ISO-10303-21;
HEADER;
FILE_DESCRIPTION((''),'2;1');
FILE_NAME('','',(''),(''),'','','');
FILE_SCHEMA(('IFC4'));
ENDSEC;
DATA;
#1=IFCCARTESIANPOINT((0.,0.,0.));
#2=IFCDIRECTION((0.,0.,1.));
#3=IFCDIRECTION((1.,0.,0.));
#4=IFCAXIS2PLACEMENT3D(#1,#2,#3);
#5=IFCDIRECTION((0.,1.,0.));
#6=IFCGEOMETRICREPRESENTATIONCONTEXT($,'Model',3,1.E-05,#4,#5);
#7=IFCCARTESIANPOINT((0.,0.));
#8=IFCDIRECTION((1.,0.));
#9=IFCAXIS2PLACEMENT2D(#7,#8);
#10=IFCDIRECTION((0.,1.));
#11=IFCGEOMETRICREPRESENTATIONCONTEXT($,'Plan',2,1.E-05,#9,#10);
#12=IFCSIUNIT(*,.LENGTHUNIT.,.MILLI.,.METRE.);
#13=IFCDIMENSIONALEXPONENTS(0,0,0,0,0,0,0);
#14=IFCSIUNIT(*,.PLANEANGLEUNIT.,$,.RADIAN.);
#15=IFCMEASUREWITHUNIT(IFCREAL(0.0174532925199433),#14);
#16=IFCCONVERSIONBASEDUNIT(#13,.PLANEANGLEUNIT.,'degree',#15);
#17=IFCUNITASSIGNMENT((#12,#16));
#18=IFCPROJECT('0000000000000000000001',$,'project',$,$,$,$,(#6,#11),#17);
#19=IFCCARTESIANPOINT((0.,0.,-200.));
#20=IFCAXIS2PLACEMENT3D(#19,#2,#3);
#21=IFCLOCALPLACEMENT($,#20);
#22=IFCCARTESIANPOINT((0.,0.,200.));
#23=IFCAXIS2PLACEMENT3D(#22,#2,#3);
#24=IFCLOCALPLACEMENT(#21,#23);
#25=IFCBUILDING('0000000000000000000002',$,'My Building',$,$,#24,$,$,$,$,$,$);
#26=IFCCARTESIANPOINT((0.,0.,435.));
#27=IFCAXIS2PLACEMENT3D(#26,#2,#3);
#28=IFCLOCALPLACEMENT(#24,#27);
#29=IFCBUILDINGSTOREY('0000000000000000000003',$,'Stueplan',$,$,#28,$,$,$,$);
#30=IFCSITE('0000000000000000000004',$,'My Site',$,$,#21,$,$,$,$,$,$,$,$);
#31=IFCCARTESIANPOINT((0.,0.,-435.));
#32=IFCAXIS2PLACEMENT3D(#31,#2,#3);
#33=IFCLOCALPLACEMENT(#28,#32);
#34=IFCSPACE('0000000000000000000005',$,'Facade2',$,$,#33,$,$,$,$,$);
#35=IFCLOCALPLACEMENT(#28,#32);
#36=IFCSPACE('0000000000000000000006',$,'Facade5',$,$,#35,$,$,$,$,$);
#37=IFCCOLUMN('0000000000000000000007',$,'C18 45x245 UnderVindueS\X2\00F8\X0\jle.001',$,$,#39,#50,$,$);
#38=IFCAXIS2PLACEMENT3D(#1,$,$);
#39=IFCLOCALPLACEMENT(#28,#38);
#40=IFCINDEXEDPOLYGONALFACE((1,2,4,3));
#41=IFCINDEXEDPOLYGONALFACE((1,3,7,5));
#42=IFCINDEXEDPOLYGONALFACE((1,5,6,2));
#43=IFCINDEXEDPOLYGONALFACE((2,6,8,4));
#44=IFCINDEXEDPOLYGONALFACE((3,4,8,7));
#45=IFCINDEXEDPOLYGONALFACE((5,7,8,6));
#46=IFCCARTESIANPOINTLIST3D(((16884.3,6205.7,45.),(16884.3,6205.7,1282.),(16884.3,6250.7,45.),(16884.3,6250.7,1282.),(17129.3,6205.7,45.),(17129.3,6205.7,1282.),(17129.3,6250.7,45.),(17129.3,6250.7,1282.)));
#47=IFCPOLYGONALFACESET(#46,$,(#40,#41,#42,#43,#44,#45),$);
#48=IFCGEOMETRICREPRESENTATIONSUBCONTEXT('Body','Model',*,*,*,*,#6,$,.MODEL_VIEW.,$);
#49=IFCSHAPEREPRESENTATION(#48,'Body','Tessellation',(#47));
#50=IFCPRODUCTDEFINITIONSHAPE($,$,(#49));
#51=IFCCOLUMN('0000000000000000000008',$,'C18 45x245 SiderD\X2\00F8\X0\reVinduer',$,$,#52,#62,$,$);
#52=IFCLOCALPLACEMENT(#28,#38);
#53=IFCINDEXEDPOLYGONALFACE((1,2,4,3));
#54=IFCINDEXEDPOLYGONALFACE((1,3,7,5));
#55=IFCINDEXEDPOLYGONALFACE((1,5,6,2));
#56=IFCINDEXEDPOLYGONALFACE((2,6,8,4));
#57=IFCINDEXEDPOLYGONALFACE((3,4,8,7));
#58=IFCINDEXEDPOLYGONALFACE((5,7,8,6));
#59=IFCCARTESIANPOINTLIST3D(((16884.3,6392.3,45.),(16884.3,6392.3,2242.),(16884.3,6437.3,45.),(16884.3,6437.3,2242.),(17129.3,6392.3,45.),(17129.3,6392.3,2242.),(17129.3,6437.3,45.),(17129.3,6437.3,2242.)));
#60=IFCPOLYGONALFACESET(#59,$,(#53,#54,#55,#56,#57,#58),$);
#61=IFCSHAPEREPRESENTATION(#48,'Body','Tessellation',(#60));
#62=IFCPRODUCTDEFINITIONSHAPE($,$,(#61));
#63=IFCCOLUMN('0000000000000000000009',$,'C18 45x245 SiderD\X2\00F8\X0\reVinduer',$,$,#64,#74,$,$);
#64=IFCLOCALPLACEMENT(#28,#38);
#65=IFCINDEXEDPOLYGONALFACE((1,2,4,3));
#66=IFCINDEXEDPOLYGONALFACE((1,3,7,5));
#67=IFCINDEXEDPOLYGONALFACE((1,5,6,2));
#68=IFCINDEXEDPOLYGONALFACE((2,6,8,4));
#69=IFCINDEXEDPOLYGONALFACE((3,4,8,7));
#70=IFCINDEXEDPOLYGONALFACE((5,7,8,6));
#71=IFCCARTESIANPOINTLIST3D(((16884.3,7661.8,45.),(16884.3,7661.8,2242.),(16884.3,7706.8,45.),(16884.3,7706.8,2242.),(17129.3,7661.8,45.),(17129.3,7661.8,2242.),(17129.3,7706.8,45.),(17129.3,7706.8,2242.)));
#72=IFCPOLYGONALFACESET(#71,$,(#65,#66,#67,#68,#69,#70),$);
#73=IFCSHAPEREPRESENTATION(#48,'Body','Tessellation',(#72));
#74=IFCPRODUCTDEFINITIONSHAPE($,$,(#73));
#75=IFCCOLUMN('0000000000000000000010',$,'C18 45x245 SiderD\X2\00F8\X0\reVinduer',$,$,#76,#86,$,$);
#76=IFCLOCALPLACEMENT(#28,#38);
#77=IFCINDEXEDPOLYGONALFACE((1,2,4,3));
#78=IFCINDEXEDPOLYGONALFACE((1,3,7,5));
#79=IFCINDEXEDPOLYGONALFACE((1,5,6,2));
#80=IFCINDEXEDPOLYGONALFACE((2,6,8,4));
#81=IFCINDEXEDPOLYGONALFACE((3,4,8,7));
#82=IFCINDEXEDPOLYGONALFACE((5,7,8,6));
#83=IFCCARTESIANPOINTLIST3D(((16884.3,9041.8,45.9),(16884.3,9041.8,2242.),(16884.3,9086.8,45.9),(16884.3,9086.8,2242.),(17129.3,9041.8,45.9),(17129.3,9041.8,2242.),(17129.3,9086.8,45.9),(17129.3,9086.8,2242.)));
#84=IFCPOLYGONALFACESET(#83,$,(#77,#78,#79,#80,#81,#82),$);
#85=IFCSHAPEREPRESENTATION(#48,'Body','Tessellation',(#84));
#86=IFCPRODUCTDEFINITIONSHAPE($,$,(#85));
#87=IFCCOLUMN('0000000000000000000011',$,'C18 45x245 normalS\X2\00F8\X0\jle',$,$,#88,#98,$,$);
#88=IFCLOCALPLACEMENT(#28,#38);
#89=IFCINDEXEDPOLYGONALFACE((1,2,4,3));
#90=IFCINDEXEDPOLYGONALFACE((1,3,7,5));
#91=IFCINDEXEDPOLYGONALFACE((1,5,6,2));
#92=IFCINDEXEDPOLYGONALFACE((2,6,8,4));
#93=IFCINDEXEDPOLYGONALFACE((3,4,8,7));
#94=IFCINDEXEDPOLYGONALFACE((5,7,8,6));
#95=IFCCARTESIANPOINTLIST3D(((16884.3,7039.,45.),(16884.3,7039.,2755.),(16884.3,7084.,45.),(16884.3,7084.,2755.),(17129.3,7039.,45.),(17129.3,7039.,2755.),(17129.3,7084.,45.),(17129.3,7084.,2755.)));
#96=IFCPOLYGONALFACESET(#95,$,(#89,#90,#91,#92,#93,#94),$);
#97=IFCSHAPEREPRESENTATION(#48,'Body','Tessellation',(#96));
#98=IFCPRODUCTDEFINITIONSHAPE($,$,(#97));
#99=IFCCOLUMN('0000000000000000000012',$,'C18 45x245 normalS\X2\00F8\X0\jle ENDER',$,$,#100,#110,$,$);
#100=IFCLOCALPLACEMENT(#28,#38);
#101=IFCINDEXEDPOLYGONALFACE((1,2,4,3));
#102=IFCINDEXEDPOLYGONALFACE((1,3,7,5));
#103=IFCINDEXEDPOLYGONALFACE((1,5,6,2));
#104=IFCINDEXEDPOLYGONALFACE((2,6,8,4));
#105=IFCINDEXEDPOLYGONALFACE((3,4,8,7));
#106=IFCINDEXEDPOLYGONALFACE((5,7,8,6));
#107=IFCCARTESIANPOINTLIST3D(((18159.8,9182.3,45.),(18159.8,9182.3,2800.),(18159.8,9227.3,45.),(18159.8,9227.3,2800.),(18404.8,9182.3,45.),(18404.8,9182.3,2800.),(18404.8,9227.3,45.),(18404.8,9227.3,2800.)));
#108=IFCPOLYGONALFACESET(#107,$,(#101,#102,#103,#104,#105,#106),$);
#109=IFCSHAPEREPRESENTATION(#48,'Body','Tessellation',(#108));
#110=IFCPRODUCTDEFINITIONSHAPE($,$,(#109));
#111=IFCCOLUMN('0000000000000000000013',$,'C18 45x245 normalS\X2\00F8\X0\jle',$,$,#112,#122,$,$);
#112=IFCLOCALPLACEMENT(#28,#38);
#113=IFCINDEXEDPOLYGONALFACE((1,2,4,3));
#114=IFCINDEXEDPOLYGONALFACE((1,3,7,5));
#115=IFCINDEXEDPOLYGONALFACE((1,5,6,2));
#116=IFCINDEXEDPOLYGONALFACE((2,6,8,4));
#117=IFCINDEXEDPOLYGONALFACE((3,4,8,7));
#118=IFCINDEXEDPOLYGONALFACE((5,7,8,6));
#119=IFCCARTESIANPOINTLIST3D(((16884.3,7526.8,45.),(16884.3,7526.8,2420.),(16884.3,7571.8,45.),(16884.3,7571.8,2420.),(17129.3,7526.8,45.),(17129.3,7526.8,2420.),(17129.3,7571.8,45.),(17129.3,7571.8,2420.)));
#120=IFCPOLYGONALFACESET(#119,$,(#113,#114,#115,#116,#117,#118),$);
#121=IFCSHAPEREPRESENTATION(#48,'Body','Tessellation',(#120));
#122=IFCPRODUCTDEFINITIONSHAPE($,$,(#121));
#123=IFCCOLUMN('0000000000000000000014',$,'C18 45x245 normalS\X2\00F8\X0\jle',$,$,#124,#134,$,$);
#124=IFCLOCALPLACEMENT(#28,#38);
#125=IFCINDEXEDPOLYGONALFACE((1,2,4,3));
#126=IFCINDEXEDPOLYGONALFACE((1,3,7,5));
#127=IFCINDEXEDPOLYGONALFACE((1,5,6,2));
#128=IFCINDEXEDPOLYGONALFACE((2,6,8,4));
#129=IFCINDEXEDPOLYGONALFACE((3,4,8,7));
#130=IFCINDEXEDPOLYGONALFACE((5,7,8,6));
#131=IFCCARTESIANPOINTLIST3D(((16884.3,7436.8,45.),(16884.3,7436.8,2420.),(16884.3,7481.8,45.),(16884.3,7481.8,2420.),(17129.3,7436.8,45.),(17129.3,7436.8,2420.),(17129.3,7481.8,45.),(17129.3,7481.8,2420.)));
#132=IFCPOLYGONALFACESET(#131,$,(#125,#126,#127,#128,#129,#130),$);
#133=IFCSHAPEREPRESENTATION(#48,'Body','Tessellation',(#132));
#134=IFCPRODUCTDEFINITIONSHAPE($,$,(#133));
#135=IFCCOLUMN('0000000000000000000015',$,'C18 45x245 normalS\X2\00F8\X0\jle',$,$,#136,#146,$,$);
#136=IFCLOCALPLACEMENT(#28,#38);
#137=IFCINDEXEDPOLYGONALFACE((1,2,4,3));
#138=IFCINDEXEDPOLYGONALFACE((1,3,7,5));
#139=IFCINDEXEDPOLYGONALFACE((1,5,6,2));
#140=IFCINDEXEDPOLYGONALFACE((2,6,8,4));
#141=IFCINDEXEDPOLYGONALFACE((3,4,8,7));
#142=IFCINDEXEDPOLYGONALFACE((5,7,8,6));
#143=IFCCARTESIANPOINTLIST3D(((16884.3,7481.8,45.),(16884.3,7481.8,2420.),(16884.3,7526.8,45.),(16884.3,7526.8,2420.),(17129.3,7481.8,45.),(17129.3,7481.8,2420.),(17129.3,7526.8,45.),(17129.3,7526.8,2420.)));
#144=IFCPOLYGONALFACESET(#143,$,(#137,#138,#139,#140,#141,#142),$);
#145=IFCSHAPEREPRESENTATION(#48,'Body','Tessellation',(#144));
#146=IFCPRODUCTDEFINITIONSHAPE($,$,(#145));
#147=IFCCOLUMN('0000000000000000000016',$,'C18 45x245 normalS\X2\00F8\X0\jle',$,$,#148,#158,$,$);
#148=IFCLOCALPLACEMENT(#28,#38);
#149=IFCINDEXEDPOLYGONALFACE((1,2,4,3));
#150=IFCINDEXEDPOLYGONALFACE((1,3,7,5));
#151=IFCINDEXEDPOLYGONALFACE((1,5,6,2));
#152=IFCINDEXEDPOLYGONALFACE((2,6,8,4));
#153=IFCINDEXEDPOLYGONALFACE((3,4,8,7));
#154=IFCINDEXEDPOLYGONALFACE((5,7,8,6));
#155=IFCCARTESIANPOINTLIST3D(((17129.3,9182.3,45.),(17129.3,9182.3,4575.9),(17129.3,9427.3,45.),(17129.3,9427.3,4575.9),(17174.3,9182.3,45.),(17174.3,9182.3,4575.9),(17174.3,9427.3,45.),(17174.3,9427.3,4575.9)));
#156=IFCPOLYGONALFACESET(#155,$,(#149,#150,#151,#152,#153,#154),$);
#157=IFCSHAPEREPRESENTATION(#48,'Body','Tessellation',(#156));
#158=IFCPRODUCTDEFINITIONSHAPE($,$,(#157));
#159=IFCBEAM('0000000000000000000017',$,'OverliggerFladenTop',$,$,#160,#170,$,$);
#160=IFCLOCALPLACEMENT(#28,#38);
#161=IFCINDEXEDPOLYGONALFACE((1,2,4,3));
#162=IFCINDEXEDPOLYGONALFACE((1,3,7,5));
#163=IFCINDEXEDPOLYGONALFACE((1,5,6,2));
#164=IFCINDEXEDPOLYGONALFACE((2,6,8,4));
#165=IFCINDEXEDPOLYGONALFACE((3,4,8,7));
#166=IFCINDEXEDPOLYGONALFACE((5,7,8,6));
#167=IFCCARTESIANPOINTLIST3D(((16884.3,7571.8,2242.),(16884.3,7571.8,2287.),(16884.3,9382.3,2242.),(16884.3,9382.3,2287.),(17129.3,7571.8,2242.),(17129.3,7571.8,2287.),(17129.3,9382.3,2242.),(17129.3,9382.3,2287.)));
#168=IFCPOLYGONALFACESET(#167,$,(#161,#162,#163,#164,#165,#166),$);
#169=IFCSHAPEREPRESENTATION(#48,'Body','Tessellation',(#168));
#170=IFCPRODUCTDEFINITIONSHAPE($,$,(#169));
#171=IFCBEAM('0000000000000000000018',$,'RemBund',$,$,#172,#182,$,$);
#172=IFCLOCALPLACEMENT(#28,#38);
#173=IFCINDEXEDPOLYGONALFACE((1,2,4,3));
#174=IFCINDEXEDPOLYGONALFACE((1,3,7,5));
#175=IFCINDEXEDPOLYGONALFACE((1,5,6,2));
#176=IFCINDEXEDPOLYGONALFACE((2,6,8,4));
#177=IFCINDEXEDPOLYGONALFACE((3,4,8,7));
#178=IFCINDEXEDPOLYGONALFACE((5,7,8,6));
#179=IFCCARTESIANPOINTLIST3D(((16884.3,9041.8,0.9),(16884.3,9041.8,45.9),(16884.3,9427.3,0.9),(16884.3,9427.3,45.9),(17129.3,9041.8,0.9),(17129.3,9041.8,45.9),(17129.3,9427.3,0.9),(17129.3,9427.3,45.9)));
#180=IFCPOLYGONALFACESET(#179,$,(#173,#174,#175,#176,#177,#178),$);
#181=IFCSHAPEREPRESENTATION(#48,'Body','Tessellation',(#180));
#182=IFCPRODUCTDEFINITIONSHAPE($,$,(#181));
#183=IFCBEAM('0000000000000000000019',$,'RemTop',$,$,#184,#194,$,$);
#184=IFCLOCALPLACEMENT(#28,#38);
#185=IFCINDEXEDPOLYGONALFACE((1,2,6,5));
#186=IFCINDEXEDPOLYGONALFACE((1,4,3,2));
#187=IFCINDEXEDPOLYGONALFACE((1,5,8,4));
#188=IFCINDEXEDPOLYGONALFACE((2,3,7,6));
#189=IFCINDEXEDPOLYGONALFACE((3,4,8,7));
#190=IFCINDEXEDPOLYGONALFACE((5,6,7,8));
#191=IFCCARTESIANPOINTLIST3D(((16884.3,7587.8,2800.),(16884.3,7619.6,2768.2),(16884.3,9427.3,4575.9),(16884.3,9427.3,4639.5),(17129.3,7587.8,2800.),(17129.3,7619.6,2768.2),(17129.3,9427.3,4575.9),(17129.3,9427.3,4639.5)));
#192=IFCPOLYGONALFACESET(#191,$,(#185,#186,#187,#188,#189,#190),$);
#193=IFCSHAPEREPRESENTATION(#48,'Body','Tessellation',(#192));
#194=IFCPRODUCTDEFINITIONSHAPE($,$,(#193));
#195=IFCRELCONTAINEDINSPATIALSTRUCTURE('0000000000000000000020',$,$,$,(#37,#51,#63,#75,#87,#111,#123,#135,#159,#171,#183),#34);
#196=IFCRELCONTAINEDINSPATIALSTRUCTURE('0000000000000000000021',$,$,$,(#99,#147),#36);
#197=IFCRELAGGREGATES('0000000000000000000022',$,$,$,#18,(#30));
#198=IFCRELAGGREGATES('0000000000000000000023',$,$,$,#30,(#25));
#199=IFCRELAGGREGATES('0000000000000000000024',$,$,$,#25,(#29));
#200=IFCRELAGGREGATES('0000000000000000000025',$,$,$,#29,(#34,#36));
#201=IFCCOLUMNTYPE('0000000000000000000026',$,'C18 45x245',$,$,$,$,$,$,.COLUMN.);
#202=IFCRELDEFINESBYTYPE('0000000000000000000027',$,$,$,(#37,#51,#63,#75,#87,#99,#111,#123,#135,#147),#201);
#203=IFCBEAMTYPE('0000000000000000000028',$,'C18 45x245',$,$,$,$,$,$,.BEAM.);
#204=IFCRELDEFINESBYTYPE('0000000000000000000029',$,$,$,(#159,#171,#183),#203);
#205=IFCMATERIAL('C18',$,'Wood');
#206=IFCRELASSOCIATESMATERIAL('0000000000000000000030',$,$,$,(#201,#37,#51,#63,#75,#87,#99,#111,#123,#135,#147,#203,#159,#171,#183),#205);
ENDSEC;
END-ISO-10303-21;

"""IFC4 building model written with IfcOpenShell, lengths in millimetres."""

from ifc_helpers import new_model, entity, si_unit, converted_unit, direction, frame, origin_with_axes, origin_2d_with_axis, place, context, subcontext, project, spatial, rectangle, extrude, clip, halfspace, material, material_profile, profile_set, profile_usage, type_object, element, save


model = new_model("IFC4")

# Units and contexts
model_context = context("Model", 3, precision=1e-05, world=origin_with_axes(), true_north=direction((0.0, 1.0, 0.0)))
plan_context = context("Plan", 2, precision=1e-05, world=origin_2d_with_axis(), true_north=direction((0.0, 1.0)))
body_context_1 = subcontext(model_context, "Body", "Model", "MODEL_VIEW")
ifc_project = project(units=[si_unit("LENGTHUNIT", "METRE", prefix="MILLI"), converted_unit("PLANEANGLEUNIT", "degree", entity("IfcReal", 0.0174532925199433), si_unit("PLANEANGLEUNIT", "RADIAN"), dimensions=[0, 0, 0, 0, 0, 0, 0])], contexts=[model_context, plan_context])

# Site, building, storey, space
site_placement = place(None, frame((0.0, 0.0, -200.0), z_axis=(0.0, 0.0, 1.0), x_axis=(1.0, 0.0, 0.0)))
site = spatial("IfcSite", under=ifc_project, at=site_placement, Name="My Site")
building_placement = place(site_placement, frame((0.0, 0.0, 200.0), z_axis=(0.0, 0.0, 1.0), x_axis=(1.0, 0.0, 0.0)))
building = spatial("IfcBuilding", under=site, at=building_placement, Name="My Building")
storey_placement = place(building_placement, frame((0.0, 0.0, 435.0), z_axis=(0.0, 0.0, 1.0), x_axis=(1.0, 0.0, 0.0)))
storey = spatial("IfcBuildingStorey", under=building, at=storey_placement, Name="Stueplan")
space_1_placement = place(storey_placement, frame((0.0, 0.0, -435.0), z_axis=(0.0, 0.0, 1.0), x_axis=(1.0, 0.0, 0.0)))
space_1 = spatial("IfcSpace", under=storey, at=space_1_placement, Name="Facade2")

# Columns
ifc_material = material(Name="C18", Category="Wood")
ifc_material_profile_1 = material_profile(ifc_material, rectangle(XDim=45.0, YDim=245.0))
ifc_profile_set_1 = profile_set([ifc_material_profile_1], Name="woodStructural")
ifc_profile_usage_1 = profile_usage(ifc_profile_set_1, cardinal=9)
column_type = type_object("IfcColumnType", Name="C18 45x245", PredefinedType="COLUMN", material=ifc_profile_set_1)
column_1_placement = place(space_1_placement, frame((17129.3, 6250.7, 480.0), z_axis=(0.0, 0.0, 1.0), x_axis=(0.0, -1.0, 0.0)))
element("IfcColumn", 1, at=column_1_placement, inside=space_1, type_object=column_type, material=ifc_profile_usage_1, Name="C18 45x245 UnderVindueSøjle.001", context=body_context_1, shape_type="SweptSolid", body=[
    extrude(rectangle(XDim=45.0, YDim=245.0), frame((22.5, -122.5, 0.0), z_axis=(0.0, 0.0, 1.0), x_axis=(1.0, 0.0, 0.0)), (0.0, 0.0, 1.0), 1237.0),
])
ifc_profile_usage_2 = profile_usage(ifc_profile_set_1, cardinal=9)
column_2_placement = place(space_1_placement, frame((17129.3, 6437.3, 480.0), z_axis=(0.0, 0.0, 1.0), x_axis=(0.0, -1.0, 0.0)))
element("IfcColumn", 2, at=column_2_placement, inside=space_1, type_object=column_type, material=ifc_profile_usage_2, Name="C18 45x245 SiderDøreVinduer", context=body_context_1, shape_type="SweptSolid", body=[
    extrude(rectangle(XDim=45.0, YDim=245.0), frame((22.5, -122.5, 0.0), z_axis=(0.0, 0.0, 1.0), x_axis=(1.0, 0.0, 0.0)), (0.0, 0.0, 1.0), 2197.0),
])
ifc_profile_usage_3 = profile_usage(ifc_profile_set_1, cardinal=9)
column_3_placement = place(space_1_placement, frame((17129.3, 7706.8, 480.0), z_axis=(0.0, 0.0, 1.0), x_axis=(0.0, -1.0, 0.0)))
element("IfcColumn", 3, at=column_3_placement, inside=space_1, type_object=column_type, material=ifc_profile_usage_3, Name="C18 45x245 SiderDøreVinduer", context=body_context_1, shape_type="SweptSolid", body=[
    extrude(rectangle(XDim=45.0, YDim=245.0), frame((22.5, -122.5, 0.0), z_axis=(0.0, 0.0, 1.0), x_axis=(1.0, 0.0, 0.0)), (0.0, 0.0, 1.0), 2197.0),
])
ifc_profile_usage_4 = profile_usage(ifc_profile_set_1, cardinal=9)
column_4_placement = place(space_1_placement, frame((17129.3, 9086.8, 480.9), z_axis=(0.0, 0.0, 1.0), x_axis=(0.0, -1.0, 0.0)))
element("IfcColumn", 4, at=column_4_placement, inside=space_1, type_object=column_type, material=ifc_profile_usage_4, Name="C18 45x245 SiderDøreVinduer", context=body_context_1, shape_type="SweptSolid", body=[
    extrude(rectangle(XDim=45.0, YDim=245.0), frame((22.5, -122.5, 0.0), z_axis=(0.0, 0.0, 1.0), x_axis=(1.0, 0.0, 0.0)), (0.0, 0.0, 1.0), 2196.1),
])
ifc_profile_usage_5 = profile_usage(ifc_profile_set_1, cardinal=9)
column_5_placement = place(space_1_placement, frame((17129.3, 7084.0, 480.0), z_axis=(0.0, 0.0, 1.0), x_axis=(0.0, -1.0, 0.0)))
element("IfcColumn", 5, at=column_5_placement, inside=space_1, type_object=column_type, material=ifc_profile_usage_5, Name="C18 45x245 normalSøjle", context=body_context_1, shape_type="SweptSolid", body=[
    extrude(rectangle(XDim=45.0, YDim=245.0), frame((22.5, -122.5, 0.0), z_axis=(0.0, 0.0, 1.0), x_axis=(1.0, 0.0, 0.0)), (0.0, 0.0, 1.0), 2710.0),
])

# Shared definitions
space_2_placement = place(storey_placement, frame((0.0, 0.0, -435.0), z_axis=(0.0, 0.0, 1.0), x_axis=(1.0, 0.0, 0.0)))
space_2 = spatial("IfcSpace", under=storey, at=space_2_placement, Name="Facade5")

# Columns
ifc_profile_usage_6 = profile_usage(ifc_profile_set_1, cardinal=9)
column_6_placement = place(space_2_placement, frame((18159.8, 9182.3, 480.0), z_axis=(0.0, 0.0, 1.0), x_axis=(0.0, 1.0, 0.0)))
element("IfcColumn", 6, at=column_6_placement, inside=space_2, type_object=column_type, material=ifc_profile_usage_6, Name="C18 45x245 normalSøjle ENDER", context=body_context_1, shape_type="SweptSolid", body=[
    extrude(rectangle(XDim=45.0, YDim=245.0), frame((22.5, -122.5, 0.0), z_axis=(0.0, 0.0, 1.0), x_axis=(1.0, 0.0, 0.0)), (0.0, 0.0, 1.0), 2755.0),
])
ifc_profile_usage_7 = profile_usage(ifc_profile_set_1, cardinal=9)
column_7_placement = place(space_1_placement, frame((17129.3, 7571.8, 480.0), z_axis=(0.0, 0.0, 1.0), x_axis=(0.0, -1.0, 0.0)))
element("IfcColumn", 7, at=column_7_placement, inside=space_1, type_object=column_type, material=ifc_profile_usage_7, Name="C18 45x245 normalSøjle", context=body_context_1, shape_type="SweptSolid", body=[
    extrude(rectangle(XDim=45.0, YDim=245.0), frame((22.5, -122.5, 0.0), z_axis=(0.0, 0.0, 1.0), x_axis=(1.0, 0.0, 0.0)), (0.0, 0.0, 1.0), 2375.0),
])
ifc_profile_usage_8 = profile_usage(ifc_profile_set_1, cardinal=9)
column_8_placement = place(space_1_placement, frame((17129.3, 7481.8, 480.0), z_axis=(0.0, 0.0, 1.0), x_axis=(0.0, -1.0, 0.0)))
element("IfcColumn", 8, at=column_8_placement, inside=space_1, type_object=column_type, material=ifc_profile_usage_8, Name="C18 45x245 normalSøjle", context=body_context_1, shape_type="SweptSolid", body=[
    extrude(rectangle(XDim=45.0, YDim=245.0), frame((22.5, -122.5, 0.0), z_axis=(0.0, 0.0, 1.0), x_axis=(1.0, 0.0, 0.0)), (0.0, 0.0, 1.0), 2375.0),
])
ifc_profile_usage_9 = profile_usage(ifc_profile_set_1, cardinal=9)
column_9_placement = place(space_1_placement, frame((17129.3, 7526.8, 480.0), z_axis=(0.0, 0.0, 1.0), x_axis=(0.0, -1.0, 0.0)))
element("IfcColumn", 9, at=column_9_placement, inside=space_1, type_object=column_type, material=ifc_profile_usage_9, Name="C18 45x245 normalSøjle", context=body_context_1, shape_type="SweptSolid", body=[
    extrude(rectangle(XDim=45.0, YDim=245.0), frame((22.5, -122.5, 0.0), z_axis=(0.0, 0.0, 1.0), x_axis=(1.0, 0.0, 0.0)), (0.0, 0.0, 1.0), 2375.0),
])
ifc_profile_usage_10 = profile_usage(ifc_profile_set_1, cardinal=9)
column_10_placement = place(space_2_placement, frame((17174.3, 9182.3, 480.0), z_axis=(0.0, 0.0, 1.0), x_axis=(-1.0, 0.0, 0.0)))
element("IfcColumn", 10, at=column_10_placement, inside=space_2, type_object=column_type, material=ifc_profile_usage_10, Name="C18 45x245 normalSøjle", context=body_context_1, shape_type="SweptSolid", body=[
    extrude(rectangle(XDim=45.0, YDim=245.0), frame((22.5, -122.5, 0.0), z_axis=(0.0, 0.0, 1.0), x_axis=(1.0, 0.0, 0.0)), (0.0, 0.0, 1.0), 4530.9),
])

# Beams
ifc_material_profile_2 = material_profile(ifc_material, rectangle(XDim=45.0, YDim=245.0), Name="concrete")
ifc_profile_set_2 = profile_set([ifc_material_profile_2], Name="woodStructural")
ifc_profile_usage_11 = profile_usage(ifc_profile_set_2)
beam_type_1 = type_object("IfcBeamType", Name="C18 45x245", PredefinedType="BEAM", material=ifc_profile_set_2)
beam_1_placement = place(space_1_placement, frame((17006.8, 7571.8, 2699.5), z_axis=(0.0, 1.0, 0.0), x_axis=(0.0, 0.0, 1.0)))
element("IfcBeam", 11, at=beam_1_placement, inside=space_1, type_object=beam_type_1, material=ifc_profile_usage_11, Name="OverliggerFladenTop", context=body_context_1, shape_type="SweptSolid", body=[
    extrude(rectangle(XDim=45.0, YDim=245.0), origin_with_axes(), (0.0, 0.0, 1.0), 1810.5),
])
ifc_profile_usage_12 = profile_usage(ifc_profile_set_2)
beam_2_placement = place(space_1_placement, frame((17006.8, 9041.8, 458.4), z_axis=(0.0, 1.0, 0.0), x_axis=(0.0, 0.0, 1.0)))
element("IfcBeam", 12, at=beam_2_placement, inside=space_1, type_object=beam_type_1, material=ifc_profile_usage_12, Name="RemBund", context=body_context_1, shape_type="SweptSolid", body=[
    extrude(rectangle(XDim=45.0, YDim=245.0), origin_with_axes(), (0.0, 0.0, 1.0), 385.5),
])
ifc_profile_usage_13 = profile_usage(ifc_profile_set_2)
beam_3_placement = place(space_1_placement, frame((17006.8, 7603.7, 3219.1), z_axis=(0.0, 0.707107, 0.707107), x_axis=(0.0, -0.707107, 0.707107)))
element("IfcBeam", 13, at=beam_3_placement, inside=space_1, type_object=beam_type_1, material=ifc_profile_usage_13, Name="RemTop", context=body_context_1, shape_type="Clipping", body=[
    clip(extrude(rectangle(XDim=45.0, YDim=245.0), origin_with_axes(), (0.0, 0.0, 1.0), 2824.0), halfspace(frame((-3226.3, 122.5, -647.3), z_axis=(-0.707107, 0.000001, 0.707107), x_axis=(0.000001, 1.0, 0.0)), False)),
])

save(model, "model.ifc")
